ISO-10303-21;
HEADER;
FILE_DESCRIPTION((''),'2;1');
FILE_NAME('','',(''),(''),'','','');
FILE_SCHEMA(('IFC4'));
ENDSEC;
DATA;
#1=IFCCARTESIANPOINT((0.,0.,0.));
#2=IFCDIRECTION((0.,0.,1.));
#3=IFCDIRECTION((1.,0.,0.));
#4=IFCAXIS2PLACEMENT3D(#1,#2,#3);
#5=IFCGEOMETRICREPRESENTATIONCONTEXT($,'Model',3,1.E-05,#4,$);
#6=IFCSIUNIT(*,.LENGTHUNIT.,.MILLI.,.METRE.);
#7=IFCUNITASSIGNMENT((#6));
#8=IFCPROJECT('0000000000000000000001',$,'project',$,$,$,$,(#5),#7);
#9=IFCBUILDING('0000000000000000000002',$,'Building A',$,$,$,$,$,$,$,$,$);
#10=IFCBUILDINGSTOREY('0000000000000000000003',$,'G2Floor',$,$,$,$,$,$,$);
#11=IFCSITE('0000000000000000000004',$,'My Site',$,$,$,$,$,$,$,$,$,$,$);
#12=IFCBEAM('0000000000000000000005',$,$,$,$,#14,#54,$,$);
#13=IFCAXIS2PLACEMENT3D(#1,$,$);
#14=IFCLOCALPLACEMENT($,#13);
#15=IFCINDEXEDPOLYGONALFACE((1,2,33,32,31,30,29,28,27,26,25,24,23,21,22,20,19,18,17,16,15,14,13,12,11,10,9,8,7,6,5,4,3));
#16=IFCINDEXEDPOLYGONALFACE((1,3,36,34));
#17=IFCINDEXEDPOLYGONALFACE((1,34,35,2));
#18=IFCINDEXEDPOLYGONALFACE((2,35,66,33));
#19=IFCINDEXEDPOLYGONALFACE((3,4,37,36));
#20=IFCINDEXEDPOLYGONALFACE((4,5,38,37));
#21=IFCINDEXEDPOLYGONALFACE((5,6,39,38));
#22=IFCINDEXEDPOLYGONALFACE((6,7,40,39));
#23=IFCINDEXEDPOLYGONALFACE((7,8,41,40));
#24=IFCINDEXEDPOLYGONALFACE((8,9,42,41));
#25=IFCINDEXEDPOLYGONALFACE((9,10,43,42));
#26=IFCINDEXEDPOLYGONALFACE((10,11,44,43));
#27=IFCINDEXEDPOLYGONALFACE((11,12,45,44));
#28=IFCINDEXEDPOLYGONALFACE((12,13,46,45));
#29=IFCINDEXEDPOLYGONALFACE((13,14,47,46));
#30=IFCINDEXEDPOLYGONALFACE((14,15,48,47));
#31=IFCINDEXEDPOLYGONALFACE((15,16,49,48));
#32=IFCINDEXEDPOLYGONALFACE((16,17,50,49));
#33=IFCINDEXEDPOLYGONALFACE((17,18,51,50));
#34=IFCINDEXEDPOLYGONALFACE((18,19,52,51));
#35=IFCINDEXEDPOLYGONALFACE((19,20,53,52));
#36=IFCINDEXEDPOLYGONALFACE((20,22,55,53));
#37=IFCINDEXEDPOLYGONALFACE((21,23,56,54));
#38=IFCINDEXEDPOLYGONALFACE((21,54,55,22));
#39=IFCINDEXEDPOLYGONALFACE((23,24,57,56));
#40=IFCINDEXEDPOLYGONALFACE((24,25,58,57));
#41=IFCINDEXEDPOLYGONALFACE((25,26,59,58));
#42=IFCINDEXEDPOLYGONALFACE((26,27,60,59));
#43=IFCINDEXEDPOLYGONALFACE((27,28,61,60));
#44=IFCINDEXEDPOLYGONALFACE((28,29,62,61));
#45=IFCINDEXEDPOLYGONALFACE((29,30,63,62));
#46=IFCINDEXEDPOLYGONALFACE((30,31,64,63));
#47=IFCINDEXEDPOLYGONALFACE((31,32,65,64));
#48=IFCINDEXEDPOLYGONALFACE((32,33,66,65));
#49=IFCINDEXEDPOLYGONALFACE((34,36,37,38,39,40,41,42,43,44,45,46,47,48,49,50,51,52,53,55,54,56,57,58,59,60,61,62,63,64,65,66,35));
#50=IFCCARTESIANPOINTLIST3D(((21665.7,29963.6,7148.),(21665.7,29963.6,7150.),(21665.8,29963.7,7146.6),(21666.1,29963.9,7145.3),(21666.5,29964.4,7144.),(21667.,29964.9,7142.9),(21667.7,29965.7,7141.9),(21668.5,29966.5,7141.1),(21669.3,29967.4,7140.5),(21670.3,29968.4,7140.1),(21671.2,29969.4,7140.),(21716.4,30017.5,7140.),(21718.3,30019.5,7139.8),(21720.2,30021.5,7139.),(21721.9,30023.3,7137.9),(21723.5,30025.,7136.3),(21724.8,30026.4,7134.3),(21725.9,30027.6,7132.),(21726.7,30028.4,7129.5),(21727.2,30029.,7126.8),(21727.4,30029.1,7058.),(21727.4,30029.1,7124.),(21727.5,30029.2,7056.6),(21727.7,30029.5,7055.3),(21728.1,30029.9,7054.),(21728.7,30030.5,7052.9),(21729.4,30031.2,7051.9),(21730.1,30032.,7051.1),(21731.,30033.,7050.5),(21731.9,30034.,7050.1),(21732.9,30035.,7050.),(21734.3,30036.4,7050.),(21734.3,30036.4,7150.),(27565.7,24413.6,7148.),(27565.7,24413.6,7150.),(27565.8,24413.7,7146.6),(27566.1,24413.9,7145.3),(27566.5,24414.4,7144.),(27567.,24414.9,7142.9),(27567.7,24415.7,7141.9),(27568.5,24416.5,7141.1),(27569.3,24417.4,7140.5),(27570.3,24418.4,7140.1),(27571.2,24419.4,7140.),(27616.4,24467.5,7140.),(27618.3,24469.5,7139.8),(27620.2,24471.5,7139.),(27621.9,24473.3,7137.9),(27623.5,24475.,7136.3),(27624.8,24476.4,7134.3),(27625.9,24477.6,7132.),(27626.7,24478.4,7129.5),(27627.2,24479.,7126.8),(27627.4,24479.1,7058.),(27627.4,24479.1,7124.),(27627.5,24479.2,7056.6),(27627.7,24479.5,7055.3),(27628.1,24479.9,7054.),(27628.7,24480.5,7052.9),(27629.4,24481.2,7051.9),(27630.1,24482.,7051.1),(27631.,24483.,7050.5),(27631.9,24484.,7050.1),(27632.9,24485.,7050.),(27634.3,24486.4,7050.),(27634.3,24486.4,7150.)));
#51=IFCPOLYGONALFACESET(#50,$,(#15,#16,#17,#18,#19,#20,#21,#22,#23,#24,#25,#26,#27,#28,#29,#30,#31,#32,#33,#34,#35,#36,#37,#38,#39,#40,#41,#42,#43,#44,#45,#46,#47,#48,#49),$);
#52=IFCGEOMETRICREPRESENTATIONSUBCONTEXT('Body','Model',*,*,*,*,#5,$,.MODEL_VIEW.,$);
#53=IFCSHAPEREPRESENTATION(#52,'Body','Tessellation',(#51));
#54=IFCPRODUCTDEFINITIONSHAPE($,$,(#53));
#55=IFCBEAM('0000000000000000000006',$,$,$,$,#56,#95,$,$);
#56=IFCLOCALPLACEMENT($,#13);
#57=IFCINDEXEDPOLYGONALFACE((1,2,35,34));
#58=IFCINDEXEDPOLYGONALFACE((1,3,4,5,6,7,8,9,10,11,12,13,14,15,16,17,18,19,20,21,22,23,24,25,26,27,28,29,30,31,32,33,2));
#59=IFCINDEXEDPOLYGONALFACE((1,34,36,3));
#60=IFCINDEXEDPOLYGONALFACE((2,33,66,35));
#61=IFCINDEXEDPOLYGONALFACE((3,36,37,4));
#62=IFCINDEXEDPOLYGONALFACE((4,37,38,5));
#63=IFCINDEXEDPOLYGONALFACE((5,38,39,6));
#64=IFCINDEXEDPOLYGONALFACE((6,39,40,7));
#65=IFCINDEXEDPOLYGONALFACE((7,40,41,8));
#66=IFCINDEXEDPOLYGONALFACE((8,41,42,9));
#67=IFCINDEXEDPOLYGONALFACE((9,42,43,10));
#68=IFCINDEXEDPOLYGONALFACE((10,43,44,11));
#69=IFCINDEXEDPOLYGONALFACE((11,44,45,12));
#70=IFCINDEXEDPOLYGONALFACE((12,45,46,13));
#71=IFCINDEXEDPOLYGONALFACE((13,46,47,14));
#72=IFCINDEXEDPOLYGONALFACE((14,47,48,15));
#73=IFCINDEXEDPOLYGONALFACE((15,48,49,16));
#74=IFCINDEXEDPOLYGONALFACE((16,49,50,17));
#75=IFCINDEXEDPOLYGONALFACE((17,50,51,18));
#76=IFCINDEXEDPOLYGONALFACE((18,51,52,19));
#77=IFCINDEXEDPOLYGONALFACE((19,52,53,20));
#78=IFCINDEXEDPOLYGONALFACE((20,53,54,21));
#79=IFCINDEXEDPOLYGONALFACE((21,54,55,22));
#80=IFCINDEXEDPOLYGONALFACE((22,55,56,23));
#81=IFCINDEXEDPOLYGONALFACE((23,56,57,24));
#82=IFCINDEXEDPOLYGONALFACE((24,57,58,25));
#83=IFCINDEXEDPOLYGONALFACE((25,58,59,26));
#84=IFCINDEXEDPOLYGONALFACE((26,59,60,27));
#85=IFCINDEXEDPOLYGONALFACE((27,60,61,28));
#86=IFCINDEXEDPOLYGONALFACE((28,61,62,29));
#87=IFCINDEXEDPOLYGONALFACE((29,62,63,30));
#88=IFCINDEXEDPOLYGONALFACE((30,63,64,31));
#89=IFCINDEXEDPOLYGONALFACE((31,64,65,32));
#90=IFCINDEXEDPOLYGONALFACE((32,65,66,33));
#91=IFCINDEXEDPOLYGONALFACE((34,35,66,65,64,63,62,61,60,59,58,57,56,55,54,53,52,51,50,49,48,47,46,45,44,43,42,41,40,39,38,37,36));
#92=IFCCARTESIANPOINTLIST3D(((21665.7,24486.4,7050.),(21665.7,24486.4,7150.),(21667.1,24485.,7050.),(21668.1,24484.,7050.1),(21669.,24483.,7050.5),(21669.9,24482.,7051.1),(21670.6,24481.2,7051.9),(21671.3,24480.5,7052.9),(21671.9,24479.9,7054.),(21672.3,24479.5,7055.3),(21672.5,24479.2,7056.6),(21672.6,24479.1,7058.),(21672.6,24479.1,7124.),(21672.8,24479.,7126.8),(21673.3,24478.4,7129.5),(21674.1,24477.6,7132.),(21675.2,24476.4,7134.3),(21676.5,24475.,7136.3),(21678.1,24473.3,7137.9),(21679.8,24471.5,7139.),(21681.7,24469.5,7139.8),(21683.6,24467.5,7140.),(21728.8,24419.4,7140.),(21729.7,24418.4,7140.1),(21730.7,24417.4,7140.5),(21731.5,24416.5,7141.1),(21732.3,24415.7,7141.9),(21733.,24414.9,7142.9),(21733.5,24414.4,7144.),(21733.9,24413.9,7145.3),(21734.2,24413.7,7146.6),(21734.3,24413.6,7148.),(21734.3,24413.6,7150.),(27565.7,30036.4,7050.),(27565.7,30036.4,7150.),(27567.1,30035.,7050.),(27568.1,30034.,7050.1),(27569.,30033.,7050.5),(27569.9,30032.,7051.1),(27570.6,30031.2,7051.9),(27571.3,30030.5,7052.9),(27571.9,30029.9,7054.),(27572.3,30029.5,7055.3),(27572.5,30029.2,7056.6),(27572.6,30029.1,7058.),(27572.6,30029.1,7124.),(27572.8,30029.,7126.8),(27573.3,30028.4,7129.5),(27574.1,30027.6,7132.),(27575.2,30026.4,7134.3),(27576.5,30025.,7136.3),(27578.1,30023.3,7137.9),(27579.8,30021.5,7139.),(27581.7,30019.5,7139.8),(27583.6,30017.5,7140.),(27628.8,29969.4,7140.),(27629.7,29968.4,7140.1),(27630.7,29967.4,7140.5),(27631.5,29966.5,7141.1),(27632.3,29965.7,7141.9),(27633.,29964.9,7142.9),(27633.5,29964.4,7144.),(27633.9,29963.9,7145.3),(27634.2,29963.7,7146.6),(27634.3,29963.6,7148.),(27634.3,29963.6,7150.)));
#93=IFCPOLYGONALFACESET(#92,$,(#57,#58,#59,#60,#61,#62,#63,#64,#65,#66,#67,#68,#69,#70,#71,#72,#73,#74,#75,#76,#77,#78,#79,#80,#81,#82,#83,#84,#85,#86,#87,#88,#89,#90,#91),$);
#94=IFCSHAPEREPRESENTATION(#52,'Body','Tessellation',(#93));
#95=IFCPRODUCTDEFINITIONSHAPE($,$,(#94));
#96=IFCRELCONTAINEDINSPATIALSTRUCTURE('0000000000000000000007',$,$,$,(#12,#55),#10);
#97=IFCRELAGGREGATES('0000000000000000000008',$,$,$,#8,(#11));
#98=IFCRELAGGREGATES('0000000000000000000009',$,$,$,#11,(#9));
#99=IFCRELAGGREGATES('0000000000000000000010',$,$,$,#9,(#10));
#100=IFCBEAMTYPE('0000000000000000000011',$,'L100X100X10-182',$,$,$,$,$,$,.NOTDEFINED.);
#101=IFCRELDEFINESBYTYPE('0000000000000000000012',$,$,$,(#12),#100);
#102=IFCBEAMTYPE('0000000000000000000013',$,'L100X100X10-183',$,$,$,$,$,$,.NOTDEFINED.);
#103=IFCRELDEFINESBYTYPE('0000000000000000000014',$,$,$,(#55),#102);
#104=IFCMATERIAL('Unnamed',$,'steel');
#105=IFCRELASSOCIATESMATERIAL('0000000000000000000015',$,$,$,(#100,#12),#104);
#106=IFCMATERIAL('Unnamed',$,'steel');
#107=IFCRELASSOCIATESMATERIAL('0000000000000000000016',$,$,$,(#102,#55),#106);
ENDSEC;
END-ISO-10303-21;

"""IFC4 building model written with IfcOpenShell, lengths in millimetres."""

from ifc_helpers import new_model, si_unit, frame, origin_with_axes, place, context, subcontext, project, spatial, polyline, outline, extrude, material, material_profile, profile_set, profile_usage, type_object, element, save


model = new_model("IFC4")

# Units and contexts
model_context = context("Model", 3, precision=1e-05, world=origin_with_axes())
body_context = subcontext(model_context, "Body", "Model", "MODEL_VIEW")
ifc_project = project(units=[si_unit("LENGTHUNIT", "METRE", prefix="MILLI")], contexts=[model_context])

# Site, building, storey
site = spatial("IfcSite", under=ifc_project, Name="My Site")
building = spatial("IfcBuilding", under=site, Name="Building A")
storey = spatial("IfcBuildingStorey", under=building, Name="G2Floor")

# Beams
ifc_material_1 = material(Name="Unnamed", Category="steel")
ifc_material_profile_1 = material_profile(ifc_material_1, outline(polyline([(-50.0, -50.0), (50.0, -50.0), (50.0, -50.0), (50.0, -48.0), (50.0, -48.0), (49.9, -46.6), (49.9, -46.6), (49.5, -45.3), (49.5, -45.3), (48.9, -44.0), (48.9, -44.0), (48.1, -42.9), (48.1, -42.9), (47.1, -41.9), (47.1, -41.9), (46.0, -41.1), (46.0, -41.1), (44.7, -40.5), (44.7, -40.5), (43.4, -40.1), (43.4, -40.1), (42.0, -40.0), (42.0, -40.0), (-24.0, -40.0), (-24.0, -40.0), (-26.8, -39.8), (-26.8, -39.8), (-29.5, -39.0), (-29.5, -39.0), (-32.0, -37.9), (-32.0, -37.9), (-34.3, -36.3), (-34.3, -36.3), (-36.3, -34.3), (-36.3, -34.3), (-37.9, -32.0), (-37.9, -32.0), (-39.0, -29.5), (-39.0, -29.5), (-39.8, -26.8), (-39.8, -26.8), (-40.0, -24.0), (-40.0, -24.0), (-40.0, 42.0), (-40.0, 42.0), (-40.1, 43.4), (-40.1, 43.4), (-40.5, 44.7), (-40.5, 44.7), (-41.1, 46.0), (-41.1, 46.0), (-41.9, 47.1), (-41.9, 47.1), (-42.9, 48.1), (-42.9, 48.1), (-44.0, 48.9), (-44.0, 48.9), (-45.3, 49.5), (-45.3, 49.5), (-46.6, 49.9), (-46.6, 49.9), (-48.0, 50.0), (-48.0, 50.0), (-50.0, 50.0), (-50.0, 50.0), (-50.0, -50.0)])))
ifc_profile_set_1 = profile_set([ifc_material_profile_1], Name="L100X100X10-182")
ifc_profile_usage_1 = profile_usage(ifc_profile_set_1)
beam_type_1 = type_object("IfcBeamType", Name="L100X100X10-182", PredefinedType="NOTDEFINED", material=ifc_profile_set_1)
beam_1_placement = place(None, frame((21700.0, 30000.0, 7100.0), z_axis=(0.728381, -0.685172, 0.0), x_axis=(-0.685172, -0.728381, 0.0)))
element("IfcBeam", 1, at=beam_1_placement, inside=storey, type_object=beam_type_1, material=ifc_profile_usage_1, context=body_context, shape_type="SweptSolid", body=[
    extrude(outline(polyline([(-50.0, -50.0), (50.0, -50.0), (50.0, -50.0), (50.0, -48.0), (50.0, -48.0), (49.9, -46.6), (49.9, -46.6), (49.5, -45.3), (49.5, -45.3), (48.9, -44.0), (48.9, -44.0), (48.1, -42.9), (48.1, -42.9), (47.1, -41.9), (47.1, -41.9), (46.0, -41.1), (46.0, -41.1), (44.7, -40.5), (44.7, -40.5), (43.4, -40.1), (43.4, -40.1), (42.0, -40.0), (42.0, -40.0), (-24.0, -40.0), (-24.0, -40.0), (-26.8, -39.8), (-26.8, -39.8), (-29.5, -39.0), (-29.5, -39.0), (-32.0, -37.9), (-32.0, -37.9), (-34.3, -36.3), (-34.3, -36.3), (-36.3, -34.3), (-36.3, -34.3), (-37.9, -32.0), (-37.9, -32.0), (-39.0, -29.5), (-39.0, -29.5), (-39.8, -26.8), (-39.8, -26.8), (-40.0, -24.0), (-40.0, -24.0), (-40.0, 42.0), (-40.0, 42.0), (-40.1, 43.4), (-40.1, 43.4), (-40.5, 44.7), (-40.5, 44.7), (-41.1, 46.0), (-41.1, 46.0), (-41.9, 47.1), (-41.9, 47.1), (-42.9, 48.1), (-42.9, 48.1), (-44.0, 48.9), (-44.0, 48.9), (-45.3, 49.5), (-45.3, 49.5), (-46.6, 49.9), (-46.6, 49.9), (-48.0, 50.0), (-48.0, 50.0), (-50.0, 50.0), (-50.0, 50.0), (-50.0, -50.0)])), origin_with_axes(), (0.0, 0.0, 1.0), 8100.2),
])
ifc_material_2 = material(Name="Unnamed", Category="steel")
ifc_material_profile_2 = material_profile(ifc_material_2, outline(polyline([(-50.0, -50.0), (50.0, -50.0), (50.0, -50.0), (50.0, -48.0), (50.0, -48.0), (49.9, -46.6), (49.9, -46.6), (49.5, -45.3), (49.5, -45.3), (48.9, -44.0), (48.9, -44.0), (48.1, -42.9), (48.1, -42.9), (47.1, -41.9), (47.1, -41.9), (46.0, -41.1), (46.0, -41.1), (44.7, -40.5), (44.7, -40.5), (43.4, -40.1), (43.4, -40.1), (42.0, -40.0), (42.0, -40.0), (-24.0, -40.0), (-24.0, -40.0), (-26.8, -39.8), (-26.8, -39.8), (-29.5, -39.0), (-29.5, -39.0), (-32.0, -37.9), (-32.0, -37.9), (-34.3, -36.3), (-34.3, -36.3), (-36.3, -34.3), (-36.3, -34.3), (-37.9, -32.0), (-37.9, -32.0), (-39.0, -29.5), (-39.0, -29.5), (-39.8, -26.8), (-39.8, -26.8), (-40.0, -24.0), (-40.0, -24.0), (-40.0, 42.0), (-40.0, 42.0), (-40.1, 43.4), (-40.1, 43.4), (-40.5, 44.7), (-40.5, 44.7), (-41.1, 46.0), (-41.1, 46.0), (-41.9, 47.1), (-41.9, 47.1), (-42.9, 48.1), (-42.9, 48.1), (-44.0, 48.9), (-44.0, 48.9), (-45.3, 49.5), (-45.3, 49.5), (-46.6, 49.9), (-46.6, 49.9), (-48.0, 50.0), (-48.0, 50.0), (-50.0, 50.0), (-50.0, 50.0), (-50.0, -50.0)])))
ifc_profile_set_2 = profile_set([ifc_material_profile_2], Name="L100X100X10-183")
ifc_profile_usage_2 = profile_usage(ifc_profile_set_2)
beam_type_2 = type_object("IfcBeamType", Name="L100X100X10-183", PredefinedType="NOTDEFINED", material=ifc_profile_set_2)
beam_2_placement = place(None, frame((21700.0, 24450.0, 7100.0), z_axis=(0.728381, 0.685172, 0.0), x_axis=(0.685172, -0.728381, 0.0)))
element("IfcBeam", 2, at=beam_2_placement, inside=storey, type_object=beam_type_2, material=ifc_profile_usage_2, context=body_context, shape_type="SweptSolid", body=[
    extrude(outline(polyline([(-50.0, -50.0), (50.0, -50.0), (50.0, -50.0), (50.0, -48.0), (50.0, -48.0), (49.9, -46.6), (49.9, -46.6), (49.5, -45.3), (49.5, -45.3), (48.9, -44.0), (48.9, -44.0), (48.1, -42.9), (48.1, -42.9), (47.1, -41.9), (47.1, -41.9), (46.0, -41.1), (46.0, -41.1), (44.7, -40.5), (44.7, -40.5), (43.4, -40.1), (43.4, -40.1), (42.0, -40.0), (42.0, -40.0), (-24.0, -40.0), (-24.0, -40.0), (-26.8, -39.8), (-26.8, -39.8), (-29.5, -39.0), (-29.5, -39.0), (-32.0, -37.9), (-32.0, -37.9), (-34.3, -36.3), (-34.3, -36.3), (-36.3, -34.3), (-36.3, -34.3), (-37.9, -32.0), (-37.9, -32.0), (-39.0, -29.5), (-39.0, -29.5), (-39.8, -26.8), (-39.8, -26.8), (-40.0, -24.0), (-40.0, -24.0), (-40.0, 42.0), (-40.0, 42.0), (-40.1, 43.4), (-40.1, 43.4), (-40.5, 44.7), (-40.5, 44.7), (-41.1, 46.0), (-41.1, 46.0), (-41.9, 47.1), (-41.9, 47.1), (-42.9, 48.1), (-42.9, 48.1), (-44.0, 48.9), (-44.0, 48.9), (-45.3, 49.5), (-45.3, 49.5), (-46.6, 49.9), (-46.6, 49.9), (-48.0, 50.0), (-48.0, 50.0), (-50.0, 50.0), (-50.0, 50.0), (-50.0, -50.0)])), origin_with_axes(), (0.0, 0.0, 1.0), 8100.2),
])

save(model, "model.ifc")
